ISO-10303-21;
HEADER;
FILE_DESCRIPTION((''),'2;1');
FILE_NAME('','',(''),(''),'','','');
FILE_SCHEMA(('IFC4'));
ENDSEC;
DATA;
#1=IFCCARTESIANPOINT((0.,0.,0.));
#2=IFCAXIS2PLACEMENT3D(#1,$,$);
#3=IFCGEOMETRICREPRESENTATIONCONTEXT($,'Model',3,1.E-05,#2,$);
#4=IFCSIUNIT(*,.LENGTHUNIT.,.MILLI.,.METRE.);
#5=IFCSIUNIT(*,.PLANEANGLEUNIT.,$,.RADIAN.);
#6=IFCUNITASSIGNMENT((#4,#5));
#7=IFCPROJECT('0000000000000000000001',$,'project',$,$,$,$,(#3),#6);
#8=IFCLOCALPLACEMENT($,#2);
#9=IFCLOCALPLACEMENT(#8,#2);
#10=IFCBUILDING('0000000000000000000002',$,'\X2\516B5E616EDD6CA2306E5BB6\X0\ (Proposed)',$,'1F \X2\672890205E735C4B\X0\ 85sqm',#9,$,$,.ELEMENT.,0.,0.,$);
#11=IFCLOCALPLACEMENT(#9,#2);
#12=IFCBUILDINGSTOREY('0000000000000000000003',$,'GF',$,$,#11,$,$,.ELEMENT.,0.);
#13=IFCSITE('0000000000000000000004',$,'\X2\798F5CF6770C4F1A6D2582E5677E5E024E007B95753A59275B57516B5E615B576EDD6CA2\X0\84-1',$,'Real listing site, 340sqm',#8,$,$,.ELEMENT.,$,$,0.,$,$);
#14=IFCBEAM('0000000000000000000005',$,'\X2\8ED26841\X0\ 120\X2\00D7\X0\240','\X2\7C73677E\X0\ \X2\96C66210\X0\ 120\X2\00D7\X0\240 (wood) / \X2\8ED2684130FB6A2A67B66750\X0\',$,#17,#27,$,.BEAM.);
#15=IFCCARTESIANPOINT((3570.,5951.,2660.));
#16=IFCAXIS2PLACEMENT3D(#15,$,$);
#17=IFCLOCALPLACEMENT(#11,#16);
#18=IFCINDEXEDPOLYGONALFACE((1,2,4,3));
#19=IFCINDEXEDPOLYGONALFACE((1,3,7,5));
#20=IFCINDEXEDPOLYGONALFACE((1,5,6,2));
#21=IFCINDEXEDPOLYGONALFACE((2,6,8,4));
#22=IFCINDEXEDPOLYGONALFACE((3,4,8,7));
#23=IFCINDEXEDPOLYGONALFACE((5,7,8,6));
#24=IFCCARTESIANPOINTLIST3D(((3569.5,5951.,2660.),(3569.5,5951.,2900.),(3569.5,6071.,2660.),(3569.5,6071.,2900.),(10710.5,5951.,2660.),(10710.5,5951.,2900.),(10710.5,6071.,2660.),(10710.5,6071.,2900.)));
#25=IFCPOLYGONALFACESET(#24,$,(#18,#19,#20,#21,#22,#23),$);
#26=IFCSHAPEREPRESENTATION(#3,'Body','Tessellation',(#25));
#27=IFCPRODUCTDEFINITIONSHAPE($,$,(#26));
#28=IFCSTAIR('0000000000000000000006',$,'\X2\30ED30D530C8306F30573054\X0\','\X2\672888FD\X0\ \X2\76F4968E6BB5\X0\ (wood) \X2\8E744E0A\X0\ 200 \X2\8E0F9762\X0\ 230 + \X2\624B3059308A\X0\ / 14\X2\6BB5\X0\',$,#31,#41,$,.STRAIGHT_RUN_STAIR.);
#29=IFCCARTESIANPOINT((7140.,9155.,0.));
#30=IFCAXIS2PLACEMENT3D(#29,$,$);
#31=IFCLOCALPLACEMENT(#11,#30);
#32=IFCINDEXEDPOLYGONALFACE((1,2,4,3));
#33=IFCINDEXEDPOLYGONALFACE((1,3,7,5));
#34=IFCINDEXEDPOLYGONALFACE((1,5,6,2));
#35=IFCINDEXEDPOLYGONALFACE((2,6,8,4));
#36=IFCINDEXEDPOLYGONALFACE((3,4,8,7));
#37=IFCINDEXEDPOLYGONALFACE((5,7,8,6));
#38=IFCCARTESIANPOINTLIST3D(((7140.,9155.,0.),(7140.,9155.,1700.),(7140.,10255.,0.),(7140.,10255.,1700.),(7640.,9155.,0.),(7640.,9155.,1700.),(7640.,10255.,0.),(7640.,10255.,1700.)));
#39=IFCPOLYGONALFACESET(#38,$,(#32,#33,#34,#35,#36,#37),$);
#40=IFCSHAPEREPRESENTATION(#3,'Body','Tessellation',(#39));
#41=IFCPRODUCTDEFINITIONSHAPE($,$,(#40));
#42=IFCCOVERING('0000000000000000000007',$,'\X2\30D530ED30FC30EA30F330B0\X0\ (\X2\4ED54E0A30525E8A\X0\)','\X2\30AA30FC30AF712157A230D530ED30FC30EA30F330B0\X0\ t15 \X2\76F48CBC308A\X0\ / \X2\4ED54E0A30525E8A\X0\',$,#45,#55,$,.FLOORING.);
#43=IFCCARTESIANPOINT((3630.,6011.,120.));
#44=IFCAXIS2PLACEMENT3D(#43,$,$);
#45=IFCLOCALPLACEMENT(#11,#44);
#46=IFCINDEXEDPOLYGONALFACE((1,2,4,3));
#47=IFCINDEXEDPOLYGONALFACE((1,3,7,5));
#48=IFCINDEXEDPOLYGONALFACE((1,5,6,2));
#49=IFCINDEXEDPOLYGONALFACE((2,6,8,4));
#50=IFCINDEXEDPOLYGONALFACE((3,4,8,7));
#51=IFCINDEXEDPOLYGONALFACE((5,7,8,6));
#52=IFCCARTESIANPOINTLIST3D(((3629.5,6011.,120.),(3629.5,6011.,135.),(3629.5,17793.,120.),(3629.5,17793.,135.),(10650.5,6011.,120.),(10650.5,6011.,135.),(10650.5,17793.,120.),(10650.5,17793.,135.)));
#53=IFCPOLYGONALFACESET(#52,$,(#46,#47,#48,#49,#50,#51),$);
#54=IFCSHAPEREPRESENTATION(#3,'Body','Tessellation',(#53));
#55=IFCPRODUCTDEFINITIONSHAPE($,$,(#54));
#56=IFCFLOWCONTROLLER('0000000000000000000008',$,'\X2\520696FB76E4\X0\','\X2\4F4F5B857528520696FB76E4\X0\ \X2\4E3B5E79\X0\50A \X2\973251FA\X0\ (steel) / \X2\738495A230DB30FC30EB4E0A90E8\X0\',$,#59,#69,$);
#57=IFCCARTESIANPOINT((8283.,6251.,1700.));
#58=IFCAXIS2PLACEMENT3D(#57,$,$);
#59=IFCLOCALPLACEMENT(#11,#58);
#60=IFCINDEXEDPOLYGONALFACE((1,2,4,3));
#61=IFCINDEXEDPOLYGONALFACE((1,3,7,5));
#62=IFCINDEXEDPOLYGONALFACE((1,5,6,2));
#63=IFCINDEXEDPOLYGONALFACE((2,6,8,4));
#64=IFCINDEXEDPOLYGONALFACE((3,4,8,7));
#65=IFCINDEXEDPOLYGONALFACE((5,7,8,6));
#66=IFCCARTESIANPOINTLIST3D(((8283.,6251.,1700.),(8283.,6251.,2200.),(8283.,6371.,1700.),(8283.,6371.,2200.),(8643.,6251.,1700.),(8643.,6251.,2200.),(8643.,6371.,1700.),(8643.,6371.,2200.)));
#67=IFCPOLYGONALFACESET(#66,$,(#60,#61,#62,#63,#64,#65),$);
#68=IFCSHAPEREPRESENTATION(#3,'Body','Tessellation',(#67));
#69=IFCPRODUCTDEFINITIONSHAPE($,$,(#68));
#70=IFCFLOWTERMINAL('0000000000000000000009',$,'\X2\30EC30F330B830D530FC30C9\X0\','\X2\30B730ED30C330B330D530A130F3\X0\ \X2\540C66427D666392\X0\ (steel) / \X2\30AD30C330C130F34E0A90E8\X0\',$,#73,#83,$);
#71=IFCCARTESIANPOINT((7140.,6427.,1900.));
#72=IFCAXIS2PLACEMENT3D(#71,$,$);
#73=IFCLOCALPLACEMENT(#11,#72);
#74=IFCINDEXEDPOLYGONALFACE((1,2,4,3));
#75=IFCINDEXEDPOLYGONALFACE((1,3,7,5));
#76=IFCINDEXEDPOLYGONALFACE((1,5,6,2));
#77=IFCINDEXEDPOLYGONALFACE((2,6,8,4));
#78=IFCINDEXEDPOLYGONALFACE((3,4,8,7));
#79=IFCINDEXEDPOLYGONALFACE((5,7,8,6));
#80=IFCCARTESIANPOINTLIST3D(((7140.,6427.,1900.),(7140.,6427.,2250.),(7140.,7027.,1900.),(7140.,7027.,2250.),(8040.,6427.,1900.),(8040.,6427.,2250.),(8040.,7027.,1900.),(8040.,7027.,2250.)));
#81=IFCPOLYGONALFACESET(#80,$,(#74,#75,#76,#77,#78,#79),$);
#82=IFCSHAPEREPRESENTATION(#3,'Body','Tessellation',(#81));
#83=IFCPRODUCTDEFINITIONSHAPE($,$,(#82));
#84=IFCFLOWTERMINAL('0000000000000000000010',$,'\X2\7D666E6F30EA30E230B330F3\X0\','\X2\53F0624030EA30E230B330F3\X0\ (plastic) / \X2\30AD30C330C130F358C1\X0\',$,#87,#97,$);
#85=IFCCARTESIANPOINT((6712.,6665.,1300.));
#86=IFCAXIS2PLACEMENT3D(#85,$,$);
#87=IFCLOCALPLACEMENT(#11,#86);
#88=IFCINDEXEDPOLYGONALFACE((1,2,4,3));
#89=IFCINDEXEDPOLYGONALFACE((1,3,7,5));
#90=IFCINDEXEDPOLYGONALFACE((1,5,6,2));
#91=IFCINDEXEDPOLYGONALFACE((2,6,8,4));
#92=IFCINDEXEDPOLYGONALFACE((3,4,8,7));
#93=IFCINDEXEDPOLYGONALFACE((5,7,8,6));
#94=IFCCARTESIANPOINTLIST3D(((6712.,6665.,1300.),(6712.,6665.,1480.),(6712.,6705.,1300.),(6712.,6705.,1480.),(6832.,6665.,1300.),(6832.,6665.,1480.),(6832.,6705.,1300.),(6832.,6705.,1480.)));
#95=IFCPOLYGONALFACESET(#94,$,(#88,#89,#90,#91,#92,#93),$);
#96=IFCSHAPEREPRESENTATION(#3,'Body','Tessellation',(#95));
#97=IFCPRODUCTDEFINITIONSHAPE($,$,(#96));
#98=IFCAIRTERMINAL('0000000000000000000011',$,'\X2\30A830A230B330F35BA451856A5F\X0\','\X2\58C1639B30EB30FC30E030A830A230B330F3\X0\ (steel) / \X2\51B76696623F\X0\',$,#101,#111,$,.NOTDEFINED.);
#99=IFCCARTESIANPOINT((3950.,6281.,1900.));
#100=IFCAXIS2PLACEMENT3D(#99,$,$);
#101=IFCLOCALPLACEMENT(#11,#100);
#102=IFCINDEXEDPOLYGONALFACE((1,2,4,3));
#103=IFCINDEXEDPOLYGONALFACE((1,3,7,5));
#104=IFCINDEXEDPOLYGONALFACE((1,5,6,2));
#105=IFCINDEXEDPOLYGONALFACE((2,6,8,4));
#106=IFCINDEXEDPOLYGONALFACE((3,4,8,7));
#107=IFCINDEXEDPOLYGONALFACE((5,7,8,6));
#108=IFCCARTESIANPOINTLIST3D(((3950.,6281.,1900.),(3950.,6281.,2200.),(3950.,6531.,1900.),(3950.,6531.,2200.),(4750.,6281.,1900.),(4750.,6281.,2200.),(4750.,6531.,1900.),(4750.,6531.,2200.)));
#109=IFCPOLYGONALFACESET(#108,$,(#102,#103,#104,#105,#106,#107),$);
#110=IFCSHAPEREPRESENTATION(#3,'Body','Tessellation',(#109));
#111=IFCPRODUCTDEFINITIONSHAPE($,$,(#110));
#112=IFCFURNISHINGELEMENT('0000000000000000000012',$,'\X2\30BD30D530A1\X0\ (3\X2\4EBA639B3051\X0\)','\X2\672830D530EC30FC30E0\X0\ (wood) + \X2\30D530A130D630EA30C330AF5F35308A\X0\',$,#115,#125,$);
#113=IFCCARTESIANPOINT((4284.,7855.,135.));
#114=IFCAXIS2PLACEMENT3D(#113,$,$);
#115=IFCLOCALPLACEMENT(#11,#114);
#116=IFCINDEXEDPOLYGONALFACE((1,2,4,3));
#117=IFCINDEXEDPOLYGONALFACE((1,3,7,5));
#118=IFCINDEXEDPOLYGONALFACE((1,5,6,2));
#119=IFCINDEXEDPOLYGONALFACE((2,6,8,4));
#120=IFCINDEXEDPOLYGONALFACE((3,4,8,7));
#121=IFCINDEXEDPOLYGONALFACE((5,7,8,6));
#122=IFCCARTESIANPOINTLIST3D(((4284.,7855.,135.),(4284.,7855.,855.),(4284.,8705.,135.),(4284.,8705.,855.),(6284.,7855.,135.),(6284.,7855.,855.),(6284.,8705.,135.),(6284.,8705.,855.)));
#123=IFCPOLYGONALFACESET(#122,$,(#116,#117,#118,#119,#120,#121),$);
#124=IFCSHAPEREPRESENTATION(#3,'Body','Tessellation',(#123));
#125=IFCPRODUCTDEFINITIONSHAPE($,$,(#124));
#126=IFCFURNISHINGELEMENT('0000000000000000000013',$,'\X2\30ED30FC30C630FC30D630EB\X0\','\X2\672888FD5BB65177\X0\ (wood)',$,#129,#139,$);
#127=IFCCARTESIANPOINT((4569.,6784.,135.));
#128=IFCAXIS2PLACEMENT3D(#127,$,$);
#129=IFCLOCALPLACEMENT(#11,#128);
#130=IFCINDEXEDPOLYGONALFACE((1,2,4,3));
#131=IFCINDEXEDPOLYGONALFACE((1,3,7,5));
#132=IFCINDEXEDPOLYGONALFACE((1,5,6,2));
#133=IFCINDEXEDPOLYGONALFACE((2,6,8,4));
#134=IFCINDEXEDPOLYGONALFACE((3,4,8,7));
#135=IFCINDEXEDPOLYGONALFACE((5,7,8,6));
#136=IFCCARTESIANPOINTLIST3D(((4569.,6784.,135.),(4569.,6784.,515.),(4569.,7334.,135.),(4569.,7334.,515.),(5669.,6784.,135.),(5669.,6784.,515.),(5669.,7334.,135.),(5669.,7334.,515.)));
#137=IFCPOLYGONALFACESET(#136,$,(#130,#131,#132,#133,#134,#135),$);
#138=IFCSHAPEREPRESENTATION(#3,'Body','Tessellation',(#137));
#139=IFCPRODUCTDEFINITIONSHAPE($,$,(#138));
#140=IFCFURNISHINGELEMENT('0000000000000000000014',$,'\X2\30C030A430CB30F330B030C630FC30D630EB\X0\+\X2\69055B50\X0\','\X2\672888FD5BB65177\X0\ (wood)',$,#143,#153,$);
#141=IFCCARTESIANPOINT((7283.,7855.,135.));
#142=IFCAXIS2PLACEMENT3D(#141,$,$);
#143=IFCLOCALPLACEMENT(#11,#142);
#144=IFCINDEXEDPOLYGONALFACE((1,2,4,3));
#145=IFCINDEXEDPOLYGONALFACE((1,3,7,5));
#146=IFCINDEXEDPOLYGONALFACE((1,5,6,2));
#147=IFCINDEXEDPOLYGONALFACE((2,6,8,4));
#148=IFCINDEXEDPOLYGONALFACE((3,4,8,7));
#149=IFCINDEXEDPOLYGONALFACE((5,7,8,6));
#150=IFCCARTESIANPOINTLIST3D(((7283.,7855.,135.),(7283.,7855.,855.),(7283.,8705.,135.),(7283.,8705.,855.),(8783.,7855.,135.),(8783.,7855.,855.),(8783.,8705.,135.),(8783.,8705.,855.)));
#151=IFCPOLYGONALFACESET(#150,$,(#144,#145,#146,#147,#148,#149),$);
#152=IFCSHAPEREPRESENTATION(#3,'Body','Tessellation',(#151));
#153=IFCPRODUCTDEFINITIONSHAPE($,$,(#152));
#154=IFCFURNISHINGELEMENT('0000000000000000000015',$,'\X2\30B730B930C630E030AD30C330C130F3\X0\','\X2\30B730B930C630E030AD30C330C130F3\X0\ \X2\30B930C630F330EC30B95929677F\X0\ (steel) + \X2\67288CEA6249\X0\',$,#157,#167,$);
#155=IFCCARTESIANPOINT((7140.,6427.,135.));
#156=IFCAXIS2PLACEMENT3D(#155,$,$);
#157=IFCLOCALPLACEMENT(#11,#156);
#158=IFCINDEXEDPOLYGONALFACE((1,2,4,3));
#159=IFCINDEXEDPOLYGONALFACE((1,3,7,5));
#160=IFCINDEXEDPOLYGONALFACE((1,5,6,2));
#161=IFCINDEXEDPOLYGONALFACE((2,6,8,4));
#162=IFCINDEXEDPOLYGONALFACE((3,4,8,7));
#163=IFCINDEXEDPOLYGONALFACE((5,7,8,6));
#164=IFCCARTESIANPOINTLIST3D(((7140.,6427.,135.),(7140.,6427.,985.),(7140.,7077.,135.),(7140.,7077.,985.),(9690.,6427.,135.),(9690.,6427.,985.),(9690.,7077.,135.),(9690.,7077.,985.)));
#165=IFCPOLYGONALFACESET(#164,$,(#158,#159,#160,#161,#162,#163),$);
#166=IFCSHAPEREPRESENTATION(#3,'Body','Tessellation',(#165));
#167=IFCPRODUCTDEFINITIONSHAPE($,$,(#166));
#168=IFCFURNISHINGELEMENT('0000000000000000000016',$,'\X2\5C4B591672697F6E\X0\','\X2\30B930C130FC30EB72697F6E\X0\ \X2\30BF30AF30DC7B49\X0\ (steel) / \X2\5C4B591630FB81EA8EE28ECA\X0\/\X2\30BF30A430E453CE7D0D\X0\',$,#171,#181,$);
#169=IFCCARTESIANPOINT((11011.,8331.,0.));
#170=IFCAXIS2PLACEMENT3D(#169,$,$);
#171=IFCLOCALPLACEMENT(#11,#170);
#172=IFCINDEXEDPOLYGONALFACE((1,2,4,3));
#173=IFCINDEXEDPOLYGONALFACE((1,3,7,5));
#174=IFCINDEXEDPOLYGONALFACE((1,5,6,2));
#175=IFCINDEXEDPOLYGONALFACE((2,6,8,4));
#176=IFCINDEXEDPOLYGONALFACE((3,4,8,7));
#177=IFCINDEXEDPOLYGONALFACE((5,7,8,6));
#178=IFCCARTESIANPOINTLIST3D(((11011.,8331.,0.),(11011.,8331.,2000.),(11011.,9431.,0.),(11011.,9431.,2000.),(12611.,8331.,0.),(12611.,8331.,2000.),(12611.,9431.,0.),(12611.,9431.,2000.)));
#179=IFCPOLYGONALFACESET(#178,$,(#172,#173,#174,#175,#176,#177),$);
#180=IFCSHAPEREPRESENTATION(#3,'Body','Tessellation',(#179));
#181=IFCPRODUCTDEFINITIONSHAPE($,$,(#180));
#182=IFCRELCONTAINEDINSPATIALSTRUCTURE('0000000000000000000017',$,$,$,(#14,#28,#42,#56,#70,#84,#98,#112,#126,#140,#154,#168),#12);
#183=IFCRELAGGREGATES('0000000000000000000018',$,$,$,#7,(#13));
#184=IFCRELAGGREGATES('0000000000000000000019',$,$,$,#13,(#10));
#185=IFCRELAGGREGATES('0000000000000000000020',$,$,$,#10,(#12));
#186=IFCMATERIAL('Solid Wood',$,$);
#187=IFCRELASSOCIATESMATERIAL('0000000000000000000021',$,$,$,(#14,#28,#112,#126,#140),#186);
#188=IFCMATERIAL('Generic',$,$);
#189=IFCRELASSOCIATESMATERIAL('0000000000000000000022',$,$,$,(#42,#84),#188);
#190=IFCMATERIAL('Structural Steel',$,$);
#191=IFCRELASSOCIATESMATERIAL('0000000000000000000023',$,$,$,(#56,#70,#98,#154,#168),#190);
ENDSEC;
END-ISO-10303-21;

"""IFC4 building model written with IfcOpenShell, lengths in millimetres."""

from ifc_helpers import new_model, si_unit, frame, frame_2d, origin, place, context, project, spatial, rectangle, extrude, material, element, save


model = new_model("IFC4")

# Units and contexts
model_context = context("Model", 3, precision=1e-05, world=origin())
ifc_project = project(units=[si_unit("LENGTHUNIT", "METRE", prefix="MILLI"), si_unit("PLANEANGLEUNIT", "RADIAN")], contexts=[model_context])

# Site, building, storey
site_placement = place(None, origin())
site = spatial("IfcSite", under=ifc_project, at=site_placement, Name="福島県会津若松市一箕町大字八幡字滝沢84-1", ObjectType="Real listing site, 340sqm", CompositionType="ELEMENT", RefElevation=0.0)
building_placement = place(site_placement, origin())
building = spatial("IfcBuilding", under=site, at=building_placement, Name="八幡滝沢の家 (Proposed)", ObjectType="1F 木造平屋 85sqm", CompositionType="ELEMENT", ElevationOfRefHeight=0.0, ElevationOfTerrain=0.0)
storey_placement = place(building_placement, origin())
storey = spatial("IfcBuildingStorey", under=building, at=storey_placement, Name="GF", CompositionType="ELEMENT", Elevation=0.0)

# Shared definitions
ifc_material_1 = material(Name="Solid Wood")

# Beam
beam_1_placement = place(storey_placement, frame((3570.0, 5951.0, 2660.0)))
element("IfcBeam", 1, at=beam_1_placement, inside=storey, material=ifc_material_1, Name="軒桁 120×240", Description="米松 集成 120×240 (wood) / 軒桁・横架材", PredefinedType="BEAM", context=model_context, shape_type="SweptSolid", body=[
    extrude(rectangle(XDim=7141.0, YDim=120.0, at=frame_2d((3570.0, 60.0))), frame((3570.0, 5951.0, 2660.0)), (0.0, 0.0, 1.0), 240.0),
])

# Stair
stair_placement = place(storey_placement, frame((7140.0, 9155.0, 0.0)))
element("IfcStair", 2, at=stair_placement, inside=storey, material=ifc_material_1, Name="ロフトはしご", Description="木製 直階段 (wood) 蹴上 200 踏面 230 + 手すり / 14段", PredefinedType="STRAIGHT_RUN_STAIR", context=model_context, shape_type="SweptSolid", body=[
    extrude(rectangle(XDim=500.0, YDim=1100.0, at=frame_2d((250.0, 550.0))), frame((7140.0, 9155.0, 0.0)), (0.0, 0.0, 1.0), 1700.0),
])

# Covering
ifc_material_2 = material(Name="Generic")
covering_placement = place(storey_placement, frame((3630.0, 6011.0, 120.0)))
element("IfcCovering", 3, at=covering_placement, inside=storey, material=ifc_material_2, Name="フローリング (仕上げ床)", Description="オーク無垢フローリング t15 直貼り / 仕上げ床", PredefinedType="FLOORING", context=model_context, shape_type="SweptSolid", body=[
    extrude(rectangle(XDim=7021.0, YDim=11782.0, at=frame_2d((3510.0, 5891.0))), frame((3630.0, 6011.0, 120.0)), (0.0, 0.0, 1.0), 15.0),
])

# Flow controller
ifc_material_3 = material(Name="Structural Steel")
flow_controller_placement = place(storey_placement, frame((8283.0, 6251.0, 1700.0)))
element("IfcFlowController", 4, at=flow_controller_placement, inside=storey, material=ifc_material_3, Name="分電盤", Description="住宅用分電盤 主幹50A 露出 (steel) / 玄関ホール上部", context=model_context, shape_type="SweptSolid", body=[
    extrude(rectangle(XDim=360.0, YDim=120.0, at=frame_2d((180.0, 60.0))), frame((8283.0, 6251.0, 1700.0)), (0.0, 0.0, 1.0), 500.0),
])

# Flow terminals
flow_terminal_1_placement = place(storey_placement, frame((7140.0, 6427.0, 1900.0)))
element("IfcFlowTerminal", 5, at=flow_terminal_1_placement, inside=storey, material=ifc_material_3, Name="レンジフード", Description="シロッコファン 同時給排 (steel) / キッチン上部", context=model_context, shape_type="SweptSolid", body=[
    extrude(rectangle(XDim=900.0, YDim=600.0, at=frame_2d((450.0, 300.0))), frame((7140.0, 6427.0, 1900.0)), (0.0, 0.0, 1.0), 350.0),
])
flow_terminal_2_placement = place(storey_placement, frame((6712.0, 6665.0, 1300.0)))
element("IfcFlowTerminal", 6, at=flow_terminal_2_placement, inside=storey, material=ifc_material_2, Name="給湯リモコン", Description="台所リモコン (plastic) / キッチン壁", context=model_context, shape_type="SweptSolid", body=[
    extrude(rectangle(XDim=120.0, YDim=40.0, at=frame_2d((60.0, 20.0))), frame((6712.0, 6665.0, 1300.0)), (0.0, 0.0, 1.0), 180.0),
])

# Air terminal
air_terminal_placement = place(storey_placement, frame((3950.0, 6281.0, 1900.0)))
element("IfcAirTerminal", 7, at=air_terminal_placement, inside=storey, material=ifc_material_3, Name="エアコン室内機", Description="壁掛ルームエアコン (steel) / 冷暖房", PredefinedType="NOTDEFINED", context=model_context, shape_type="SweptSolid", body=[
    extrude(rectangle(XDim=800.0, YDim=250.0, at=frame_2d((400.0, 125.0))), frame((3950.0, 6281.0, 1900.0)), (0.0, 0.0, 1.0), 300.0),
])

# Furnishing elements
furnishing_1_placement = place(storey_placement, frame((4284.0, 7855.0, 135.0)))
element("IfcFurnishingElement", 8, at=furnishing_1_placement, inside=storey, material=ifc_material_1, Name="ソファ (3人掛け)", Description="木フレーム (wood) + ファブリック張り", context=model_context, shape_type="SweptSolid", body=[
    extrude(rectangle(XDim=2000.0, YDim=850.0, at=frame_2d((1000.0, 425.0))), frame((4284.0, 7855.0, 135.0)), (0.0, 0.0, 1.0), 720.0),
])
furnishing_2_placement = place(storey_placement, frame((4569.0, 6784.0, 135.0)))
element("IfcFurnishingElement", 9, at=furnishing_2_placement, inside=storey, material=ifc_material_1, Name="ローテーブル", Description="木製家具 (wood)", context=model_context, shape_type="SweptSolid", body=[
    extrude(rectangle(XDim=1100.0, YDim=550.0, at=frame_2d((550.0, 275.0))), frame((4569.0, 6784.0, 135.0)), (0.0, 0.0, 1.0), 380.0),
])
furnishing_3_placement = place(storey_placement, frame((7283.0, 7855.0, 135.0)))
element("IfcFurnishingElement", 10, at=furnishing_3_placement, inside=storey, material=ifc_material_1, Name="ダイニングテーブル+椅子", Description="木製家具 (wood)", context=model_context, shape_type="SweptSolid", body=[
    extrude(rectangle(XDim=1500.0, YDim=850.0, at=frame_2d((750.0, 425.0))), frame((7283.0, 7855.0, 135.0)), (0.0, 0.0, 1.0), 720.0),
])
furnishing_4_placement = place(storey_placement, frame((7140.0, 6427.0, 135.0)))
element("IfcFurnishingElement", 11, at=furnishing_4_placement, inside=storey, material=ifc_material_3, Name="システムキッチン", Description="システムキッチン ステンレス天板 (steel) + 木質扉", context=model_context, shape_type="SweptSolid", body=[
    extrude(rectangle(XDim=2550.0, YDim=650.0, at=frame_2d((1275.0, 325.0))), frame((7140.0, 6427.0, 135.0)), (0.0, 0.0, 1.0), 850.0),
])
furnishing_5_placement = place(storey_placement, frame((11011.0, 8331.0, 0.0)))
element("IfcFurnishingElement", 12, at=furnishing_5_placement, inside=storey, material=ifc_material_3, Name="屋外物置", Description="スチール物置 タクボ等 (steel) / 屋外・自転車/タイヤ収納", context=model_context, shape_type="SweptSolid", body=[
    extrude(rectangle(XDim=1600.0, YDim=1100.0, at=frame_2d((800.0, 550.0))), frame((11011.0, 8331.0, 0.0)), (0.0, 0.0, 1.0), 2000.0),
])

save(model, "model.ifc")
